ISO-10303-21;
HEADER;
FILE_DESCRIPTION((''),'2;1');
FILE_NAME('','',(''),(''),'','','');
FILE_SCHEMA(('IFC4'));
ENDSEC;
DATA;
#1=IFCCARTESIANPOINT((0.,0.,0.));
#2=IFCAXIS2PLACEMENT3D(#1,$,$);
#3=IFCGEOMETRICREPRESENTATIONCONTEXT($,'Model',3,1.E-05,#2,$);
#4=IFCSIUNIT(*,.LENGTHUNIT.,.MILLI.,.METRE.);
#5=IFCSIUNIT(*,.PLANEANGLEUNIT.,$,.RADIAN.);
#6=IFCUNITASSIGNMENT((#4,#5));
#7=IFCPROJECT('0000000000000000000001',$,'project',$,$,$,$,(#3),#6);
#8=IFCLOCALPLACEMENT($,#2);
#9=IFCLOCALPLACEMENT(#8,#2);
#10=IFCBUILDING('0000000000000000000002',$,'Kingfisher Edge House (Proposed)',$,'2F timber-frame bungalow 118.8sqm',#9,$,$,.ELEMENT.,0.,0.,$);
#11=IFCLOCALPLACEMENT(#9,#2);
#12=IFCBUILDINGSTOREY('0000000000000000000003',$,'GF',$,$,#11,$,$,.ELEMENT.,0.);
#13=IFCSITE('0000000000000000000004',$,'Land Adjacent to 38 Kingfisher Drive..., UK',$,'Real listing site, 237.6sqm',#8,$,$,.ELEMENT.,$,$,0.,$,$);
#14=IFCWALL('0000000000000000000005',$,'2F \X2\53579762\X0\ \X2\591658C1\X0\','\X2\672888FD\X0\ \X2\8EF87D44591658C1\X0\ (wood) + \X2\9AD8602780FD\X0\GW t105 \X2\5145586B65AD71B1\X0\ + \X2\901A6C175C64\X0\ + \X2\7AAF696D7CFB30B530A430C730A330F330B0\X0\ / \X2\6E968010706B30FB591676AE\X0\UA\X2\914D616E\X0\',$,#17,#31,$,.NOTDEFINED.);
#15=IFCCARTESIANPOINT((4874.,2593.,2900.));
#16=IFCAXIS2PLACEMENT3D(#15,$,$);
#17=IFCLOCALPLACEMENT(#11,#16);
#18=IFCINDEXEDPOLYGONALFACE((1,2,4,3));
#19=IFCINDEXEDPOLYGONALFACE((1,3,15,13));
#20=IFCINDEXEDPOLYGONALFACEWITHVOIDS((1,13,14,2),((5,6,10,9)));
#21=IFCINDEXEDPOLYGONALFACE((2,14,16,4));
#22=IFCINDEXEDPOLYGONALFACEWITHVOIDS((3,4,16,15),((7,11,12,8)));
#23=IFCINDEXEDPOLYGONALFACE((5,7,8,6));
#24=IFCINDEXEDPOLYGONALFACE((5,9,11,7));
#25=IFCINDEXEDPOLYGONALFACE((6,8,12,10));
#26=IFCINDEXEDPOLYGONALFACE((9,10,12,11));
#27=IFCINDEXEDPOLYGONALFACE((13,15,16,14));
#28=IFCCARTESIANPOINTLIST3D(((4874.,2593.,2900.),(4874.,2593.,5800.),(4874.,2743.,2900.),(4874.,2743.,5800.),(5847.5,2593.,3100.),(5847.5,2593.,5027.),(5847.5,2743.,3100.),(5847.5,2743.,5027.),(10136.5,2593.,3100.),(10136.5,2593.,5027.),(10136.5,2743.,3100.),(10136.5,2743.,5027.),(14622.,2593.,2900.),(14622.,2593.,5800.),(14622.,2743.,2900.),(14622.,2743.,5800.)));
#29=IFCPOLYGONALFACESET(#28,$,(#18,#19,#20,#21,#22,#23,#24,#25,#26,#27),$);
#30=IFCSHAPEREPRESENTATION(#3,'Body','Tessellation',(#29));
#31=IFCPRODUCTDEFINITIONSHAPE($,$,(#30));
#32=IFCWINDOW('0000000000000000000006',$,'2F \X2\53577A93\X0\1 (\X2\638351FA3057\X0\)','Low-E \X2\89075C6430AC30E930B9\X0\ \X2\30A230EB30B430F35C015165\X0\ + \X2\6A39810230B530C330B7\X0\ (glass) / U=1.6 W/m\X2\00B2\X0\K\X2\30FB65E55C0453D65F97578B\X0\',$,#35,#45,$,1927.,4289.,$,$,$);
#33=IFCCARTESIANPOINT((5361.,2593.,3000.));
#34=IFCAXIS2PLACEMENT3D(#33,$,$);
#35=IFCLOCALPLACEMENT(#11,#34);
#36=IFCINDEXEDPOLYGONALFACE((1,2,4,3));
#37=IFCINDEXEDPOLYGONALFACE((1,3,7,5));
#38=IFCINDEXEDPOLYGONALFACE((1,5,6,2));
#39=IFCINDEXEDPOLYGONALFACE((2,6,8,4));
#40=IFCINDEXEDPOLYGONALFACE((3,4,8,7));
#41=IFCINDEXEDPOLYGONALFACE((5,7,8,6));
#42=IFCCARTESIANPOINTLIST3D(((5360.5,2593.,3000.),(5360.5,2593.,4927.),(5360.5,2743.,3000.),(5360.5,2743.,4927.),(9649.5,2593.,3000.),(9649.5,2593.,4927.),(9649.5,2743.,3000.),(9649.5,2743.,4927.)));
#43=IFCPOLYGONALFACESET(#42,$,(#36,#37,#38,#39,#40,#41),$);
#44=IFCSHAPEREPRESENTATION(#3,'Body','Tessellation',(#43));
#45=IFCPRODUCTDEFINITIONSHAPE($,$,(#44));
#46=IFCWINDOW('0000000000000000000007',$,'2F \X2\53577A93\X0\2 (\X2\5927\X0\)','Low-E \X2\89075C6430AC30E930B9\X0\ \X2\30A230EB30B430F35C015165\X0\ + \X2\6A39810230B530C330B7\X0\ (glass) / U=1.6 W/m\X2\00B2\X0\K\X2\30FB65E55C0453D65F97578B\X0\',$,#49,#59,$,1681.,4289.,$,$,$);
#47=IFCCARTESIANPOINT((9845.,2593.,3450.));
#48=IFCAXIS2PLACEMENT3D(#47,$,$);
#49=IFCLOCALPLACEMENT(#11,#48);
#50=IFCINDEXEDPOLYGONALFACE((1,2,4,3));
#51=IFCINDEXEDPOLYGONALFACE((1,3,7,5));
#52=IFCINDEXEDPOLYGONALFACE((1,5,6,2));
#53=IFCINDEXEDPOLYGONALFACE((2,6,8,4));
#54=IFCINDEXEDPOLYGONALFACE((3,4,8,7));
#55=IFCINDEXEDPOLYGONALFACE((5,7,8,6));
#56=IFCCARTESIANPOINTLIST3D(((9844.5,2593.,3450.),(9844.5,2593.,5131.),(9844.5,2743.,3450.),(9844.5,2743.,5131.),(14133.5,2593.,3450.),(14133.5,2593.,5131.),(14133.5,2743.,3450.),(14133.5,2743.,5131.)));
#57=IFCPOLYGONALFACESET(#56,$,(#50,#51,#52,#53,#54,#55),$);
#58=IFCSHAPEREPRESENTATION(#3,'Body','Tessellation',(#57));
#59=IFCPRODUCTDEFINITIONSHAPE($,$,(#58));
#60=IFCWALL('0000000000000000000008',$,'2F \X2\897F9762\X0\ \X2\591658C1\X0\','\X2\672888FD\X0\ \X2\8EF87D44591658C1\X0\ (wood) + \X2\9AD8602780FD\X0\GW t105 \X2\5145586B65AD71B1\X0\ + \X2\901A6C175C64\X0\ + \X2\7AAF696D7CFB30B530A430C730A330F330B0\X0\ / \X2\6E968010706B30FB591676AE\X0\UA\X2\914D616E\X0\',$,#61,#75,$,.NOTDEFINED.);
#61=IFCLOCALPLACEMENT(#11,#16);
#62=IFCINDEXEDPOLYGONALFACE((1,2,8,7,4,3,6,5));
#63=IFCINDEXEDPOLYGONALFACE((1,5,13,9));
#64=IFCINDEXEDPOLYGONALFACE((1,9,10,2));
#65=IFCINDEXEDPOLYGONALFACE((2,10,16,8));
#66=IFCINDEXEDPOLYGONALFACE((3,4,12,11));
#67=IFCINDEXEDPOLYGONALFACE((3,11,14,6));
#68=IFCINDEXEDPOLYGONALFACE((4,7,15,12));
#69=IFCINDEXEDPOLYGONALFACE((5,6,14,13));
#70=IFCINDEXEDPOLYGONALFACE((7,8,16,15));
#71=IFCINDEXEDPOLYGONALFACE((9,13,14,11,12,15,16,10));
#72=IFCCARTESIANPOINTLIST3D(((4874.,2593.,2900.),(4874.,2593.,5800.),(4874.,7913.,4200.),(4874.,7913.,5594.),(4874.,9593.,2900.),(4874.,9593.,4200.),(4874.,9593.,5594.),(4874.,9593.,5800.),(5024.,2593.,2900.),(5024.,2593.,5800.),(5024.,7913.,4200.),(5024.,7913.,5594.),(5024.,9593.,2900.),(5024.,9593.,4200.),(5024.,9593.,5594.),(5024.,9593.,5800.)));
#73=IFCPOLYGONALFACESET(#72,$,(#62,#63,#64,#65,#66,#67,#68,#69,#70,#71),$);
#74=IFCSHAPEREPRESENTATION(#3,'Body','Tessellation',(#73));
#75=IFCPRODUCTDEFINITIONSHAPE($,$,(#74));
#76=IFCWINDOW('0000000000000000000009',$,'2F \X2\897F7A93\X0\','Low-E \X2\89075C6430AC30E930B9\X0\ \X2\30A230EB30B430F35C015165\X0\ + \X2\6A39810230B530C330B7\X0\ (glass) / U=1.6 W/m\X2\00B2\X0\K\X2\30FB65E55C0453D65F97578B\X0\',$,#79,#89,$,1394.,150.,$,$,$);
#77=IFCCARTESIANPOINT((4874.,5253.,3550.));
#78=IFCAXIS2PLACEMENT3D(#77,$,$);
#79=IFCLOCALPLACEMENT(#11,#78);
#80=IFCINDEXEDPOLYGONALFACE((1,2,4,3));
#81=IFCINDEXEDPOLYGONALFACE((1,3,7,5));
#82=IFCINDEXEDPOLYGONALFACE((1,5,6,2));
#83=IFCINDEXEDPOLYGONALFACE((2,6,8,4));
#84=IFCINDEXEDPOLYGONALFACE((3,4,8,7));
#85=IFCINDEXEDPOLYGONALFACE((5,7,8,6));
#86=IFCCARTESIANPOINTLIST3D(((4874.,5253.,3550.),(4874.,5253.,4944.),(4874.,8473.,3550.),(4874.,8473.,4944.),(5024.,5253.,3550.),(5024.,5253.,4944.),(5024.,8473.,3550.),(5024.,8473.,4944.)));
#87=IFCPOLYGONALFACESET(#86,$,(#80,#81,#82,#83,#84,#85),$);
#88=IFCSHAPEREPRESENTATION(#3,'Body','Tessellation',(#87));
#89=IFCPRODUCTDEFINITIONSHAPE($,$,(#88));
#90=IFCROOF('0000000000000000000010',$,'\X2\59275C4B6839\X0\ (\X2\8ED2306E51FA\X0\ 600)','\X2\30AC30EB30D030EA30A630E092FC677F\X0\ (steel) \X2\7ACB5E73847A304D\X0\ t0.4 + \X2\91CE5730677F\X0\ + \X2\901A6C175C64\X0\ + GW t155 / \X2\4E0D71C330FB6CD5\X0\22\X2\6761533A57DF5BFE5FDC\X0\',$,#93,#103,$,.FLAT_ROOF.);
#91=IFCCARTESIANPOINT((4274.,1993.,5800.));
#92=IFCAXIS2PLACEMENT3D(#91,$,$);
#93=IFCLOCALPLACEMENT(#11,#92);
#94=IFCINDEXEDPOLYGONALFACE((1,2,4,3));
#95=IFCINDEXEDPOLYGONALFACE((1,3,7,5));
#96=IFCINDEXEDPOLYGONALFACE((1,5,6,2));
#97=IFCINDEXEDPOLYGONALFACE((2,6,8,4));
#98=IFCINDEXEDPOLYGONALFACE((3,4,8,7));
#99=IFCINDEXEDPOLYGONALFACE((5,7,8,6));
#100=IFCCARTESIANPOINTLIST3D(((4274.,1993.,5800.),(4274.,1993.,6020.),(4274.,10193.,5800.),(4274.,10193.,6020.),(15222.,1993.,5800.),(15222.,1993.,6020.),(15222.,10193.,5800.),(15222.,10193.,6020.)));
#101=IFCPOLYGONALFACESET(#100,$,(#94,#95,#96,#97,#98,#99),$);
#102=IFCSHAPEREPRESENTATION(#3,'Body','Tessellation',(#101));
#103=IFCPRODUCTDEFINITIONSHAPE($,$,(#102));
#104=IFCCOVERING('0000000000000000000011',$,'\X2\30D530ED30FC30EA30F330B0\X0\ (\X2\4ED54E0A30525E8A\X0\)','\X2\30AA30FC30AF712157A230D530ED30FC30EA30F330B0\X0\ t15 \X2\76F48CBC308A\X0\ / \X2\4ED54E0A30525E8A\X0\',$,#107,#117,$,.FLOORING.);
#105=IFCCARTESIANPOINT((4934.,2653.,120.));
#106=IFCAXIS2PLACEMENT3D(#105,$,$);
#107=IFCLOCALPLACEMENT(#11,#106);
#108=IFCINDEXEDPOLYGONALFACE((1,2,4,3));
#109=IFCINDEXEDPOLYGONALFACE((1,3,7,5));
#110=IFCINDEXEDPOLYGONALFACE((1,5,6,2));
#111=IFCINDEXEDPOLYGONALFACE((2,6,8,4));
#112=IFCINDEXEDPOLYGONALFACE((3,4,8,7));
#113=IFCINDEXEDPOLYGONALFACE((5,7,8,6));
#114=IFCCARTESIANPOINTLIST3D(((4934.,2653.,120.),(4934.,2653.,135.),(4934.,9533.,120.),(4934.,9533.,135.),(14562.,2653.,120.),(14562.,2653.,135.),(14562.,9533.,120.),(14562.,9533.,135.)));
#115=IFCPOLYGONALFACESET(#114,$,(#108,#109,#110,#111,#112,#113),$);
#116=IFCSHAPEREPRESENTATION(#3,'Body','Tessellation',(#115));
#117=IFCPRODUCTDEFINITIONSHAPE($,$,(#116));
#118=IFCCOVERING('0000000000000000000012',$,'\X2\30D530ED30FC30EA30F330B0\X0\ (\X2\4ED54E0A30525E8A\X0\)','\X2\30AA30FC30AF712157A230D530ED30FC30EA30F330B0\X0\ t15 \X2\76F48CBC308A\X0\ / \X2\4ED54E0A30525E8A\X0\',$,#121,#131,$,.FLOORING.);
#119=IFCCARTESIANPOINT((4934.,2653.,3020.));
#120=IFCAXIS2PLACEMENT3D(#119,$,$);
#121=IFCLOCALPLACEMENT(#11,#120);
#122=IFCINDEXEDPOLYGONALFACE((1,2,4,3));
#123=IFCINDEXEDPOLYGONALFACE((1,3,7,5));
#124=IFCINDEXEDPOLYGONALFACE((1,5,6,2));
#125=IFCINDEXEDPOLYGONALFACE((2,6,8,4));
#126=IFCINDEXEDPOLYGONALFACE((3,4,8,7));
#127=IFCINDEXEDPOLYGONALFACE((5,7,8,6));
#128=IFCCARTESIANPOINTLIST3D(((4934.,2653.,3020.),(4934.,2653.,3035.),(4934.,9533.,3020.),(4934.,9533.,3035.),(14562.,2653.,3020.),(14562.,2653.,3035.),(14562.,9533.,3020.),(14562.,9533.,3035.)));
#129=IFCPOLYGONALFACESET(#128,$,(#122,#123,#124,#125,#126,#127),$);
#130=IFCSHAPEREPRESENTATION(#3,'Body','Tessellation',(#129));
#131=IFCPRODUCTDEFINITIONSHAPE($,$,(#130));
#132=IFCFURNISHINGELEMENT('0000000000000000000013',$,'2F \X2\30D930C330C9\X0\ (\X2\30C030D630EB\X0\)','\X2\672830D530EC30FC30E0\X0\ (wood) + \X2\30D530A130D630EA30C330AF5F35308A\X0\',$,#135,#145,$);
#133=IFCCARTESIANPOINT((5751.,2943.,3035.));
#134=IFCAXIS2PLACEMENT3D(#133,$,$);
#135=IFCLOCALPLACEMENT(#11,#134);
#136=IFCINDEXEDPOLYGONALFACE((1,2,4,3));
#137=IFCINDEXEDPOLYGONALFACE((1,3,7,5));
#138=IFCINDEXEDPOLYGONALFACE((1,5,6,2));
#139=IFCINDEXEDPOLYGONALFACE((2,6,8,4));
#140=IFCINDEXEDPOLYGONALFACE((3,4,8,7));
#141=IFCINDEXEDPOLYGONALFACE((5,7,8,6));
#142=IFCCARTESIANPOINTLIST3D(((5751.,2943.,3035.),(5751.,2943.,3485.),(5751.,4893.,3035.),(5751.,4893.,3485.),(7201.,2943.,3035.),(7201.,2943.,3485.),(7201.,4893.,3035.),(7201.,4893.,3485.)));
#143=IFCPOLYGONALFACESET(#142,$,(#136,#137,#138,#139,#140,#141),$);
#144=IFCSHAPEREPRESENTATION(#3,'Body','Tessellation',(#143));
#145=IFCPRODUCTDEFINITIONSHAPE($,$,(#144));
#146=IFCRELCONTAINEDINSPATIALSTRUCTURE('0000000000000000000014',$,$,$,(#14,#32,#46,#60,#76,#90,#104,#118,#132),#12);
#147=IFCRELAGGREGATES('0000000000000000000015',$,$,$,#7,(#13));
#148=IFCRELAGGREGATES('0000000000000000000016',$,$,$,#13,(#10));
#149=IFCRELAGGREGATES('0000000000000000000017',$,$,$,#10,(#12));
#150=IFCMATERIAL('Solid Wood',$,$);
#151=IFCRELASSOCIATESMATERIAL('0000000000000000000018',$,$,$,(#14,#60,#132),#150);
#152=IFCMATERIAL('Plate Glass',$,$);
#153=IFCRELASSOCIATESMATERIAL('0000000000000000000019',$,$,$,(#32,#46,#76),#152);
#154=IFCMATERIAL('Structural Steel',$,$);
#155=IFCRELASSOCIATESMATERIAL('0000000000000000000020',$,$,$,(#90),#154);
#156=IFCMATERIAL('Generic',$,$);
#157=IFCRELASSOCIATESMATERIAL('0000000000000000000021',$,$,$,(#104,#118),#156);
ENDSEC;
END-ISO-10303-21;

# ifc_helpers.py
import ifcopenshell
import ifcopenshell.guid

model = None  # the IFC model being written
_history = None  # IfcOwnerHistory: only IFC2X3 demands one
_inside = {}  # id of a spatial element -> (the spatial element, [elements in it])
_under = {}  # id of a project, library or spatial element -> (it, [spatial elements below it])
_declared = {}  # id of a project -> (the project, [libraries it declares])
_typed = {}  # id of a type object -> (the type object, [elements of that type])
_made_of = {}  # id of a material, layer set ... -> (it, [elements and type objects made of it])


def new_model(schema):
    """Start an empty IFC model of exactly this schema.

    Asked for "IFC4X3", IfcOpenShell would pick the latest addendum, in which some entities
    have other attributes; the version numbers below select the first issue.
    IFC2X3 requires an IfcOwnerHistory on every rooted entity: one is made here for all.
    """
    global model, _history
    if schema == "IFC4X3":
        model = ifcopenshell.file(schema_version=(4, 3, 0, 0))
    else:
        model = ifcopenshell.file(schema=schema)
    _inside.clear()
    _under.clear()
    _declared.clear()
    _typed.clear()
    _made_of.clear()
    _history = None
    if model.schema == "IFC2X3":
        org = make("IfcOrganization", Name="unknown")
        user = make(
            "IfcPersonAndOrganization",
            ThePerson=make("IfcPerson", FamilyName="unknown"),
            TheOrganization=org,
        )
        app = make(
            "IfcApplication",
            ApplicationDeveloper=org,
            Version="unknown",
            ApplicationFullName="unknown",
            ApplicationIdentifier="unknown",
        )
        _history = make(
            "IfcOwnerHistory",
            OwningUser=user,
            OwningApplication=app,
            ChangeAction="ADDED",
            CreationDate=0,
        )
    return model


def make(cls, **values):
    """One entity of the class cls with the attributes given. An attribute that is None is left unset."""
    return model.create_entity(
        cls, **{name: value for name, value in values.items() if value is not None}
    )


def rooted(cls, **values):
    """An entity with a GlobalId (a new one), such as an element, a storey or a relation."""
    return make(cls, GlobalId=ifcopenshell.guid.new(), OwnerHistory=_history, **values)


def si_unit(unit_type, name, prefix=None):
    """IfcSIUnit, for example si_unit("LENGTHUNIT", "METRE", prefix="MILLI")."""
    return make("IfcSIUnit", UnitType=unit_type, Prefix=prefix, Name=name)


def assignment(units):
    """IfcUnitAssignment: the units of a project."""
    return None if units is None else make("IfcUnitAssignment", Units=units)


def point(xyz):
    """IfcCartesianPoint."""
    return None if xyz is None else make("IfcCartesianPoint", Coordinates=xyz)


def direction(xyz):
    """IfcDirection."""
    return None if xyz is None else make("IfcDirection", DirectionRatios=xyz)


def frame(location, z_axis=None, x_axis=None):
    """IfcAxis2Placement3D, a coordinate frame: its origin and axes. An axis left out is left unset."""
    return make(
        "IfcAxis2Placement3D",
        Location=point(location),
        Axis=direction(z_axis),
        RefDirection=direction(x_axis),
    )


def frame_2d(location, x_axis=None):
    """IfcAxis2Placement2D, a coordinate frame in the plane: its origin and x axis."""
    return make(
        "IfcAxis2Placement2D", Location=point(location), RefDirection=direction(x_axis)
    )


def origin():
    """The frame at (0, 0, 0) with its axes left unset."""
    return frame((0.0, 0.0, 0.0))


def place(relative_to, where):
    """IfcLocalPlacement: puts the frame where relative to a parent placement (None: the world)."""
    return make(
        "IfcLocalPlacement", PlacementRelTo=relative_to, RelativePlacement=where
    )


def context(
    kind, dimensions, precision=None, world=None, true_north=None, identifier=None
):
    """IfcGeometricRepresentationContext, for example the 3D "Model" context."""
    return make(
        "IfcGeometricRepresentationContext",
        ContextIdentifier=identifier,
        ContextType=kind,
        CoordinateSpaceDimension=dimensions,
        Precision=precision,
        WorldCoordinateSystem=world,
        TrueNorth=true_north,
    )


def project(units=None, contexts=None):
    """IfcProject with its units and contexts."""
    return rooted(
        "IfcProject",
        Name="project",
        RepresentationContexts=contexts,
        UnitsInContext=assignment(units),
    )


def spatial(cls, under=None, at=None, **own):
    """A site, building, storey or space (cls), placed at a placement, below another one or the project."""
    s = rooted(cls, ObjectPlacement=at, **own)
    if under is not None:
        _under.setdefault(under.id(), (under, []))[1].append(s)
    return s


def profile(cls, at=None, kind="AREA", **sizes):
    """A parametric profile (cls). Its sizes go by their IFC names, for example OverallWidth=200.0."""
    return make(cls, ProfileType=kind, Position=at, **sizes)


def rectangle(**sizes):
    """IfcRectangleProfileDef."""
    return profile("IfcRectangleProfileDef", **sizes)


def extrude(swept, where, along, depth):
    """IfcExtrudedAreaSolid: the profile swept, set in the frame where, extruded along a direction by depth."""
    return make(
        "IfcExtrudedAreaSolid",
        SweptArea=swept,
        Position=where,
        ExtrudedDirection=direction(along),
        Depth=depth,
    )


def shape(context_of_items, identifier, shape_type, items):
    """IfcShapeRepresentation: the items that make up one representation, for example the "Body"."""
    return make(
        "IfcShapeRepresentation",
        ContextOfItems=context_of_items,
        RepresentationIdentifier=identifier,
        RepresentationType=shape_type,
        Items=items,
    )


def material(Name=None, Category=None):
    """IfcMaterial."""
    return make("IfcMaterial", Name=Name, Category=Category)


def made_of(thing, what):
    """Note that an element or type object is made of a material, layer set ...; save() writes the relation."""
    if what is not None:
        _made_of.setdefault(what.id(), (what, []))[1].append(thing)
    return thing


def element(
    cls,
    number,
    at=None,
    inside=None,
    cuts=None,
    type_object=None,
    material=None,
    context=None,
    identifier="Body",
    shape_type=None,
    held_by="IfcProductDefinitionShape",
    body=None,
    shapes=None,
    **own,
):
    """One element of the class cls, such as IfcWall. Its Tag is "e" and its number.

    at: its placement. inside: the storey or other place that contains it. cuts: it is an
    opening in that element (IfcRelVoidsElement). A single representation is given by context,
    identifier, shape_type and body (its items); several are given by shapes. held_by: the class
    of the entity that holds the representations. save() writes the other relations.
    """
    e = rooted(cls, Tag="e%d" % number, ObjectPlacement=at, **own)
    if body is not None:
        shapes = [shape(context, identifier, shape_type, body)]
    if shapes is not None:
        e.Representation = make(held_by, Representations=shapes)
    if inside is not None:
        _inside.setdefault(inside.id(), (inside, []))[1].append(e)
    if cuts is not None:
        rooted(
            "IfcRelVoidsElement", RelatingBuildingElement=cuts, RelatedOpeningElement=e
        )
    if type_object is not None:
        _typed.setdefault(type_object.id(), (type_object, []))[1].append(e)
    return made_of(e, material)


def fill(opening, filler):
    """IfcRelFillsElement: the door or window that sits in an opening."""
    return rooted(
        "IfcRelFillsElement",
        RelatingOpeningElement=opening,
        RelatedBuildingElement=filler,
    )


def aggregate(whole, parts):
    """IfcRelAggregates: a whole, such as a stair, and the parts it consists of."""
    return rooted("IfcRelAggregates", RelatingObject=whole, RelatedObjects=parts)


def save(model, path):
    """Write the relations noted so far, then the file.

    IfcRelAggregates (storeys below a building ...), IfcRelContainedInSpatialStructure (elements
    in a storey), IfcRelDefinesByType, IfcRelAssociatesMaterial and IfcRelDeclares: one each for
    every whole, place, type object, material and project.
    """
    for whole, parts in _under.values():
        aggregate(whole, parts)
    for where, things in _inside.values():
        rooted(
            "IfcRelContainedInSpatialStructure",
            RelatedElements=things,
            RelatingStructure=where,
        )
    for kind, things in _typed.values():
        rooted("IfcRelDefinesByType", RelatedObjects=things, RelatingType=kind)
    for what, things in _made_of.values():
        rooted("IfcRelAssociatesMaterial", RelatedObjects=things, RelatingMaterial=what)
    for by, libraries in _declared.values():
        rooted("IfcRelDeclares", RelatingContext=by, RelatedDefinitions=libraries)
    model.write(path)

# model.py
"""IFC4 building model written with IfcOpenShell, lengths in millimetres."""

from ifc_helpers import new_model, si_unit, frame, frame_2d, origin, place, context, project, spatial, rectangle, extrude, material, element, fill, save


model = new_model("IFC4")

# Units and contexts
model_context = context("Model", 3, precision=1e-05, world=origin())
ifc_project = project(units=[si_unit("LENGTHUNIT", "METRE", prefix="MILLI"), si_unit("PLANEANGLEUNIT", "RADIAN")], contexts=[model_context])

# Site, building, storey
site_placement = place(None, origin())
site = spatial("IfcSite", under=ifc_project, at=site_placement, Name="Land Adjacent to 38 Kingfisher Drive..., UK", ObjectType="Real listing site, 237.6sqm", CompositionType="ELEMENT", RefElevation=0.0)
building_placement = place(site_placement, origin())
building = spatial("IfcBuilding", under=site, at=building_placement, Name="Kingfisher Edge House (Proposed)", ObjectType="2F timber-frame bungalow 118.8sqm", CompositionType="ELEMENT", ElevationOfRefHeight=0.0, ElevationOfTerrain=0.0)
storey_placement = place(building_placement, origin())
storey = spatial("IfcBuildingStorey", under=building, at=storey_placement, Name="GF", CompositionType="ELEMENT", Elevation=0.0)

# Shared definitions
ifc_material_1 = material(Name="Solid Wood")

# Shared definitions
ifc_material_2 = material(Name="Plate Glass")

# Wall, openings, windows
wall_1_placement = place(storey_placement, frame((4874.0, 2593.0, 2900.0)))
wall_1 = element("IfcWall", 1, at=wall_1_placement, inside=storey, material=ifc_material_1, Name="2F 南面 外壁", Description="木製 軸組外壁 (wood) + 高性能GW t105 充填断熱 + 通気層 + 窯業系サイディング / 準耐火・外皮UA配慮", PredefinedType="NOTDEFINED", context=model_context, shape_type="SweptSolid", body=[
    extrude(rectangle(XDim=9748.0, YDim=150.0, at=frame_2d((4874.0, 75.0))), frame((4874.0, 2593.0, 2900.0)), (0.0, 0.0, 1.0), 2900.0),
])
opening_1_placement = place(storey_placement, frame((5361.0, 2593.0, 3000.0)))
opening_1 = element("IfcOpeningElement", 2, at=opening_1_placement, cuts=wall_1, PredefinedType="NOTDEFINED", context=model_context, shape_type="SweptSolid", body=[
    extrude(rectangle(XDim=4289.0, YDim=150.0, at=frame_2d((2144.0, 75.0))), frame((5361.0, 2593.0, 3000.0)), (0.0, 0.0, 1.0), 1927.0),
])
opening_2_placement = place(storey_placement, frame((9845.0, 2593.0, 3450.0)))
opening_2 = element("IfcOpeningElement", 3, at=opening_2_placement, cuts=wall_1, PredefinedType="NOTDEFINED", context=model_context, shape_type="SweptSolid", body=[
    extrude(rectangle(XDim=4289.0, YDim=150.0, at=frame_2d((2144.0, 75.0))), frame((9845.0, 2593.0, 3450.0)), (0.0, 0.0, 1.0), 1681.0),
])
window_1_placement = place(storey_placement, frame((5361.0, 2593.0, 3000.0)))
window_1 = element("IfcWindow", 4, at=window_1_placement, inside=storey, material=ifc_material_2, Name="2F 南窓1 (掃出し)", Description="Low-E 複層ガラス アルゴン封入 + 樹脂サッシ (glass) / U=1.6 W/m²K・日射取得型", OverallHeight=1927.0, OverallWidth=4289.0, context=model_context, shape_type="SweptSolid", body=[
    extrude(rectangle(XDim=4289.0, YDim=150.0, at=frame_2d((2144.0, 75.0))), frame((5361.0, 2593.0, 3000.0)), (0.0, 0.0, 1.0), 1927.0),
])
fill(opening_1, window_1)
window_2_placement = place(storey_placement, frame((9845.0, 2593.0, 3450.0)))
window_2 = element("IfcWindow", 5, at=window_2_placement, inside=storey, material=ifc_material_2, Name="2F 南窓2 (大)", Description="Low-E 複層ガラス アルゴン封入 + 樹脂サッシ (glass) / U=1.6 W/m²K・日射取得型", OverallHeight=1681.0, OverallWidth=4289.0, context=model_context, shape_type="SweptSolid", body=[
    extrude(rectangle(XDim=4289.0, YDim=150.0, at=frame_2d((2144.0, 75.0))), frame((9845.0, 2593.0, 3450.0)), (0.0, 0.0, 1.0), 1681.0),
])
fill(opening_2, window_2)

# Wall, opening, window
wall_2_placement = place(storey_placement, frame((4874.0, 2593.0, 2900.0)))
wall_2 = element("IfcWall", 6, at=wall_2_placement, inside=storey, material=ifc_material_1, Name="2F 西面 外壁", Description="木製 軸組外壁 (wood) + 高性能GW t105 充填断熱 + 通気層 + 窯業系サイディング / 準耐火・外皮UA配慮", PredefinedType="NOTDEFINED", context=model_context, shape_type="SweptSolid", body=[
    extrude(rectangle(XDim=150.0, YDim=7000.0, at=frame_2d((75.0, 3500.0))), frame((4874.0, 2593.0, 2900.0)), (0.0, 0.0, 1.0), 2900.0),
])
opening_3_placement = place(storey_placement, frame((4874.0, 5253.0, 3550.0)))
opening_3 = element("IfcOpeningElement", 7, at=opening_3_placement, cuts=wall_2, PredefinedType="NOTDEFINED", context=model_context, shape_type="SweptSolid", body=[
    extrude(rectangle(XDim=150.0, YDim=3220.0, at=frame_2d((75.0, 1610.0))), frame((4874.0, 5253.0, 3550.0)), (0.0, 0.0, 1.0), 1394.0),
])
window_3_placement = place(storey_placement, frame((4874.0, 5253.0, 3550.0)))
window_3 = element("IfcWindow", 8, at=window_3_placement, inside=storey, material=ifc_material_2, Name="2F 西窓", Description="Low-E 複層ガラス アルゴン封入 + 樹脂サッシ (glass) / U=1.6 W/m²K・日射取得型", OverallHeight=1394.0, OverallWidth=150.0, context=model_context, shape_type="SweptSolid", body=[
    extrude(rectangle(XDim=150.0, YDim=3220.0, at=frame_2d((75.0, 1610.0))), frame((4874.0, 5253.0, 3550.0)), (0.0, 0.0, 1.0), 1394.0),
])
fill(opening_3, window_3)

# Roof
ifc_material_3 = material(Name="Structural Steel")
roof_placement = place(storey_placement, frame((4274.0, 1993.0, 5800.0)))
element("IfcRoof", 9, at=roof_placement, inside=storey, material=ifc_material_3, Name="大屋根 (軒の出 600)", Description="ガルバリウム鋼板 (steel) 立平葺き t0.4 + 野地板 + 通気層 + GW t155 / 不燃・法22条区域対応", PredefinedType="FLAT_ROOF", context=model_context, shape_type="SweptSolid", body=[
    extrude(rectangle(XDim=10948.0, YDim=8200.0, at=frame_2d((5474.0, 4100.0))), frame((4274.0, 1993.0, 5800.0)), (0.0, 0.0, 1.0), 220.0),
])

# Coverings
ifc_material_4 = material(Name="Generic")
covering_1_placement = place(storey_placement, frame((4934.0, 2653.0, 120.0)))
element("IfcCovering", 10, at=covering_1_placement, inside=storey, material=ifc_material_4, Name="フローリング (仕上げ床)", Description="オーク無垢フローリング t15 直貼り / 仕上げ床", PredefinedType="FLOORING", context=model_context, shape_type="SweptSolid", body=[
    extrude(rectangle(XDim=9628.0, YDim=6880.0, at=frame_2d((4814.0, 3440.0))), frame((4934.0, 2653.0, 120.0)), (0.0, 0.0, 1.0), 15.0),
])
covering_2_placement = place(storey_placement, frame((4934.0, 2653.0, 3020.0)))
element("IfcCovering", 11, at=covering_2_placement, inside=storey, material=ifc_material_4, Name="フローリング (仕上げ床)", Description="オーク無垢フローリング t15 直貼り / 仕上げ床", PredefinedType="FLOORING", context=model_context, shape_type="SweptSolid", body=[
    extrude(rectangle(XDim=9628.0, YDim=6880.0, at=frame_2d((4814.0, 3440.0))), frame((4934.0, 2653.0, 3020.0)), (0.0, 0.0, 1.0), 15.0),
])

# Furnishing element
furnishing_placement = place(storey_placement, frame((5751.0, 2943.0, 3035.0)))
element("IfcFurnishingElement", 12, at=furnishing_placement, inside=storey, material=ifc_material_1, Name="2F ベッド (ダブル)", Description="木フレーム (wood) + ファブリック張り", context=model_context, shape_type="SweptSolid", body=[
    extrude(rectangle(XDim=1450.0, YDim=1950.0, at=frame_2d((725.0, 975.0))), frame((5751.0, 2943.0, 3035.0)), (0.0, 0.0, 1.0), 450.0),
])

save(model, "model.ifc")
